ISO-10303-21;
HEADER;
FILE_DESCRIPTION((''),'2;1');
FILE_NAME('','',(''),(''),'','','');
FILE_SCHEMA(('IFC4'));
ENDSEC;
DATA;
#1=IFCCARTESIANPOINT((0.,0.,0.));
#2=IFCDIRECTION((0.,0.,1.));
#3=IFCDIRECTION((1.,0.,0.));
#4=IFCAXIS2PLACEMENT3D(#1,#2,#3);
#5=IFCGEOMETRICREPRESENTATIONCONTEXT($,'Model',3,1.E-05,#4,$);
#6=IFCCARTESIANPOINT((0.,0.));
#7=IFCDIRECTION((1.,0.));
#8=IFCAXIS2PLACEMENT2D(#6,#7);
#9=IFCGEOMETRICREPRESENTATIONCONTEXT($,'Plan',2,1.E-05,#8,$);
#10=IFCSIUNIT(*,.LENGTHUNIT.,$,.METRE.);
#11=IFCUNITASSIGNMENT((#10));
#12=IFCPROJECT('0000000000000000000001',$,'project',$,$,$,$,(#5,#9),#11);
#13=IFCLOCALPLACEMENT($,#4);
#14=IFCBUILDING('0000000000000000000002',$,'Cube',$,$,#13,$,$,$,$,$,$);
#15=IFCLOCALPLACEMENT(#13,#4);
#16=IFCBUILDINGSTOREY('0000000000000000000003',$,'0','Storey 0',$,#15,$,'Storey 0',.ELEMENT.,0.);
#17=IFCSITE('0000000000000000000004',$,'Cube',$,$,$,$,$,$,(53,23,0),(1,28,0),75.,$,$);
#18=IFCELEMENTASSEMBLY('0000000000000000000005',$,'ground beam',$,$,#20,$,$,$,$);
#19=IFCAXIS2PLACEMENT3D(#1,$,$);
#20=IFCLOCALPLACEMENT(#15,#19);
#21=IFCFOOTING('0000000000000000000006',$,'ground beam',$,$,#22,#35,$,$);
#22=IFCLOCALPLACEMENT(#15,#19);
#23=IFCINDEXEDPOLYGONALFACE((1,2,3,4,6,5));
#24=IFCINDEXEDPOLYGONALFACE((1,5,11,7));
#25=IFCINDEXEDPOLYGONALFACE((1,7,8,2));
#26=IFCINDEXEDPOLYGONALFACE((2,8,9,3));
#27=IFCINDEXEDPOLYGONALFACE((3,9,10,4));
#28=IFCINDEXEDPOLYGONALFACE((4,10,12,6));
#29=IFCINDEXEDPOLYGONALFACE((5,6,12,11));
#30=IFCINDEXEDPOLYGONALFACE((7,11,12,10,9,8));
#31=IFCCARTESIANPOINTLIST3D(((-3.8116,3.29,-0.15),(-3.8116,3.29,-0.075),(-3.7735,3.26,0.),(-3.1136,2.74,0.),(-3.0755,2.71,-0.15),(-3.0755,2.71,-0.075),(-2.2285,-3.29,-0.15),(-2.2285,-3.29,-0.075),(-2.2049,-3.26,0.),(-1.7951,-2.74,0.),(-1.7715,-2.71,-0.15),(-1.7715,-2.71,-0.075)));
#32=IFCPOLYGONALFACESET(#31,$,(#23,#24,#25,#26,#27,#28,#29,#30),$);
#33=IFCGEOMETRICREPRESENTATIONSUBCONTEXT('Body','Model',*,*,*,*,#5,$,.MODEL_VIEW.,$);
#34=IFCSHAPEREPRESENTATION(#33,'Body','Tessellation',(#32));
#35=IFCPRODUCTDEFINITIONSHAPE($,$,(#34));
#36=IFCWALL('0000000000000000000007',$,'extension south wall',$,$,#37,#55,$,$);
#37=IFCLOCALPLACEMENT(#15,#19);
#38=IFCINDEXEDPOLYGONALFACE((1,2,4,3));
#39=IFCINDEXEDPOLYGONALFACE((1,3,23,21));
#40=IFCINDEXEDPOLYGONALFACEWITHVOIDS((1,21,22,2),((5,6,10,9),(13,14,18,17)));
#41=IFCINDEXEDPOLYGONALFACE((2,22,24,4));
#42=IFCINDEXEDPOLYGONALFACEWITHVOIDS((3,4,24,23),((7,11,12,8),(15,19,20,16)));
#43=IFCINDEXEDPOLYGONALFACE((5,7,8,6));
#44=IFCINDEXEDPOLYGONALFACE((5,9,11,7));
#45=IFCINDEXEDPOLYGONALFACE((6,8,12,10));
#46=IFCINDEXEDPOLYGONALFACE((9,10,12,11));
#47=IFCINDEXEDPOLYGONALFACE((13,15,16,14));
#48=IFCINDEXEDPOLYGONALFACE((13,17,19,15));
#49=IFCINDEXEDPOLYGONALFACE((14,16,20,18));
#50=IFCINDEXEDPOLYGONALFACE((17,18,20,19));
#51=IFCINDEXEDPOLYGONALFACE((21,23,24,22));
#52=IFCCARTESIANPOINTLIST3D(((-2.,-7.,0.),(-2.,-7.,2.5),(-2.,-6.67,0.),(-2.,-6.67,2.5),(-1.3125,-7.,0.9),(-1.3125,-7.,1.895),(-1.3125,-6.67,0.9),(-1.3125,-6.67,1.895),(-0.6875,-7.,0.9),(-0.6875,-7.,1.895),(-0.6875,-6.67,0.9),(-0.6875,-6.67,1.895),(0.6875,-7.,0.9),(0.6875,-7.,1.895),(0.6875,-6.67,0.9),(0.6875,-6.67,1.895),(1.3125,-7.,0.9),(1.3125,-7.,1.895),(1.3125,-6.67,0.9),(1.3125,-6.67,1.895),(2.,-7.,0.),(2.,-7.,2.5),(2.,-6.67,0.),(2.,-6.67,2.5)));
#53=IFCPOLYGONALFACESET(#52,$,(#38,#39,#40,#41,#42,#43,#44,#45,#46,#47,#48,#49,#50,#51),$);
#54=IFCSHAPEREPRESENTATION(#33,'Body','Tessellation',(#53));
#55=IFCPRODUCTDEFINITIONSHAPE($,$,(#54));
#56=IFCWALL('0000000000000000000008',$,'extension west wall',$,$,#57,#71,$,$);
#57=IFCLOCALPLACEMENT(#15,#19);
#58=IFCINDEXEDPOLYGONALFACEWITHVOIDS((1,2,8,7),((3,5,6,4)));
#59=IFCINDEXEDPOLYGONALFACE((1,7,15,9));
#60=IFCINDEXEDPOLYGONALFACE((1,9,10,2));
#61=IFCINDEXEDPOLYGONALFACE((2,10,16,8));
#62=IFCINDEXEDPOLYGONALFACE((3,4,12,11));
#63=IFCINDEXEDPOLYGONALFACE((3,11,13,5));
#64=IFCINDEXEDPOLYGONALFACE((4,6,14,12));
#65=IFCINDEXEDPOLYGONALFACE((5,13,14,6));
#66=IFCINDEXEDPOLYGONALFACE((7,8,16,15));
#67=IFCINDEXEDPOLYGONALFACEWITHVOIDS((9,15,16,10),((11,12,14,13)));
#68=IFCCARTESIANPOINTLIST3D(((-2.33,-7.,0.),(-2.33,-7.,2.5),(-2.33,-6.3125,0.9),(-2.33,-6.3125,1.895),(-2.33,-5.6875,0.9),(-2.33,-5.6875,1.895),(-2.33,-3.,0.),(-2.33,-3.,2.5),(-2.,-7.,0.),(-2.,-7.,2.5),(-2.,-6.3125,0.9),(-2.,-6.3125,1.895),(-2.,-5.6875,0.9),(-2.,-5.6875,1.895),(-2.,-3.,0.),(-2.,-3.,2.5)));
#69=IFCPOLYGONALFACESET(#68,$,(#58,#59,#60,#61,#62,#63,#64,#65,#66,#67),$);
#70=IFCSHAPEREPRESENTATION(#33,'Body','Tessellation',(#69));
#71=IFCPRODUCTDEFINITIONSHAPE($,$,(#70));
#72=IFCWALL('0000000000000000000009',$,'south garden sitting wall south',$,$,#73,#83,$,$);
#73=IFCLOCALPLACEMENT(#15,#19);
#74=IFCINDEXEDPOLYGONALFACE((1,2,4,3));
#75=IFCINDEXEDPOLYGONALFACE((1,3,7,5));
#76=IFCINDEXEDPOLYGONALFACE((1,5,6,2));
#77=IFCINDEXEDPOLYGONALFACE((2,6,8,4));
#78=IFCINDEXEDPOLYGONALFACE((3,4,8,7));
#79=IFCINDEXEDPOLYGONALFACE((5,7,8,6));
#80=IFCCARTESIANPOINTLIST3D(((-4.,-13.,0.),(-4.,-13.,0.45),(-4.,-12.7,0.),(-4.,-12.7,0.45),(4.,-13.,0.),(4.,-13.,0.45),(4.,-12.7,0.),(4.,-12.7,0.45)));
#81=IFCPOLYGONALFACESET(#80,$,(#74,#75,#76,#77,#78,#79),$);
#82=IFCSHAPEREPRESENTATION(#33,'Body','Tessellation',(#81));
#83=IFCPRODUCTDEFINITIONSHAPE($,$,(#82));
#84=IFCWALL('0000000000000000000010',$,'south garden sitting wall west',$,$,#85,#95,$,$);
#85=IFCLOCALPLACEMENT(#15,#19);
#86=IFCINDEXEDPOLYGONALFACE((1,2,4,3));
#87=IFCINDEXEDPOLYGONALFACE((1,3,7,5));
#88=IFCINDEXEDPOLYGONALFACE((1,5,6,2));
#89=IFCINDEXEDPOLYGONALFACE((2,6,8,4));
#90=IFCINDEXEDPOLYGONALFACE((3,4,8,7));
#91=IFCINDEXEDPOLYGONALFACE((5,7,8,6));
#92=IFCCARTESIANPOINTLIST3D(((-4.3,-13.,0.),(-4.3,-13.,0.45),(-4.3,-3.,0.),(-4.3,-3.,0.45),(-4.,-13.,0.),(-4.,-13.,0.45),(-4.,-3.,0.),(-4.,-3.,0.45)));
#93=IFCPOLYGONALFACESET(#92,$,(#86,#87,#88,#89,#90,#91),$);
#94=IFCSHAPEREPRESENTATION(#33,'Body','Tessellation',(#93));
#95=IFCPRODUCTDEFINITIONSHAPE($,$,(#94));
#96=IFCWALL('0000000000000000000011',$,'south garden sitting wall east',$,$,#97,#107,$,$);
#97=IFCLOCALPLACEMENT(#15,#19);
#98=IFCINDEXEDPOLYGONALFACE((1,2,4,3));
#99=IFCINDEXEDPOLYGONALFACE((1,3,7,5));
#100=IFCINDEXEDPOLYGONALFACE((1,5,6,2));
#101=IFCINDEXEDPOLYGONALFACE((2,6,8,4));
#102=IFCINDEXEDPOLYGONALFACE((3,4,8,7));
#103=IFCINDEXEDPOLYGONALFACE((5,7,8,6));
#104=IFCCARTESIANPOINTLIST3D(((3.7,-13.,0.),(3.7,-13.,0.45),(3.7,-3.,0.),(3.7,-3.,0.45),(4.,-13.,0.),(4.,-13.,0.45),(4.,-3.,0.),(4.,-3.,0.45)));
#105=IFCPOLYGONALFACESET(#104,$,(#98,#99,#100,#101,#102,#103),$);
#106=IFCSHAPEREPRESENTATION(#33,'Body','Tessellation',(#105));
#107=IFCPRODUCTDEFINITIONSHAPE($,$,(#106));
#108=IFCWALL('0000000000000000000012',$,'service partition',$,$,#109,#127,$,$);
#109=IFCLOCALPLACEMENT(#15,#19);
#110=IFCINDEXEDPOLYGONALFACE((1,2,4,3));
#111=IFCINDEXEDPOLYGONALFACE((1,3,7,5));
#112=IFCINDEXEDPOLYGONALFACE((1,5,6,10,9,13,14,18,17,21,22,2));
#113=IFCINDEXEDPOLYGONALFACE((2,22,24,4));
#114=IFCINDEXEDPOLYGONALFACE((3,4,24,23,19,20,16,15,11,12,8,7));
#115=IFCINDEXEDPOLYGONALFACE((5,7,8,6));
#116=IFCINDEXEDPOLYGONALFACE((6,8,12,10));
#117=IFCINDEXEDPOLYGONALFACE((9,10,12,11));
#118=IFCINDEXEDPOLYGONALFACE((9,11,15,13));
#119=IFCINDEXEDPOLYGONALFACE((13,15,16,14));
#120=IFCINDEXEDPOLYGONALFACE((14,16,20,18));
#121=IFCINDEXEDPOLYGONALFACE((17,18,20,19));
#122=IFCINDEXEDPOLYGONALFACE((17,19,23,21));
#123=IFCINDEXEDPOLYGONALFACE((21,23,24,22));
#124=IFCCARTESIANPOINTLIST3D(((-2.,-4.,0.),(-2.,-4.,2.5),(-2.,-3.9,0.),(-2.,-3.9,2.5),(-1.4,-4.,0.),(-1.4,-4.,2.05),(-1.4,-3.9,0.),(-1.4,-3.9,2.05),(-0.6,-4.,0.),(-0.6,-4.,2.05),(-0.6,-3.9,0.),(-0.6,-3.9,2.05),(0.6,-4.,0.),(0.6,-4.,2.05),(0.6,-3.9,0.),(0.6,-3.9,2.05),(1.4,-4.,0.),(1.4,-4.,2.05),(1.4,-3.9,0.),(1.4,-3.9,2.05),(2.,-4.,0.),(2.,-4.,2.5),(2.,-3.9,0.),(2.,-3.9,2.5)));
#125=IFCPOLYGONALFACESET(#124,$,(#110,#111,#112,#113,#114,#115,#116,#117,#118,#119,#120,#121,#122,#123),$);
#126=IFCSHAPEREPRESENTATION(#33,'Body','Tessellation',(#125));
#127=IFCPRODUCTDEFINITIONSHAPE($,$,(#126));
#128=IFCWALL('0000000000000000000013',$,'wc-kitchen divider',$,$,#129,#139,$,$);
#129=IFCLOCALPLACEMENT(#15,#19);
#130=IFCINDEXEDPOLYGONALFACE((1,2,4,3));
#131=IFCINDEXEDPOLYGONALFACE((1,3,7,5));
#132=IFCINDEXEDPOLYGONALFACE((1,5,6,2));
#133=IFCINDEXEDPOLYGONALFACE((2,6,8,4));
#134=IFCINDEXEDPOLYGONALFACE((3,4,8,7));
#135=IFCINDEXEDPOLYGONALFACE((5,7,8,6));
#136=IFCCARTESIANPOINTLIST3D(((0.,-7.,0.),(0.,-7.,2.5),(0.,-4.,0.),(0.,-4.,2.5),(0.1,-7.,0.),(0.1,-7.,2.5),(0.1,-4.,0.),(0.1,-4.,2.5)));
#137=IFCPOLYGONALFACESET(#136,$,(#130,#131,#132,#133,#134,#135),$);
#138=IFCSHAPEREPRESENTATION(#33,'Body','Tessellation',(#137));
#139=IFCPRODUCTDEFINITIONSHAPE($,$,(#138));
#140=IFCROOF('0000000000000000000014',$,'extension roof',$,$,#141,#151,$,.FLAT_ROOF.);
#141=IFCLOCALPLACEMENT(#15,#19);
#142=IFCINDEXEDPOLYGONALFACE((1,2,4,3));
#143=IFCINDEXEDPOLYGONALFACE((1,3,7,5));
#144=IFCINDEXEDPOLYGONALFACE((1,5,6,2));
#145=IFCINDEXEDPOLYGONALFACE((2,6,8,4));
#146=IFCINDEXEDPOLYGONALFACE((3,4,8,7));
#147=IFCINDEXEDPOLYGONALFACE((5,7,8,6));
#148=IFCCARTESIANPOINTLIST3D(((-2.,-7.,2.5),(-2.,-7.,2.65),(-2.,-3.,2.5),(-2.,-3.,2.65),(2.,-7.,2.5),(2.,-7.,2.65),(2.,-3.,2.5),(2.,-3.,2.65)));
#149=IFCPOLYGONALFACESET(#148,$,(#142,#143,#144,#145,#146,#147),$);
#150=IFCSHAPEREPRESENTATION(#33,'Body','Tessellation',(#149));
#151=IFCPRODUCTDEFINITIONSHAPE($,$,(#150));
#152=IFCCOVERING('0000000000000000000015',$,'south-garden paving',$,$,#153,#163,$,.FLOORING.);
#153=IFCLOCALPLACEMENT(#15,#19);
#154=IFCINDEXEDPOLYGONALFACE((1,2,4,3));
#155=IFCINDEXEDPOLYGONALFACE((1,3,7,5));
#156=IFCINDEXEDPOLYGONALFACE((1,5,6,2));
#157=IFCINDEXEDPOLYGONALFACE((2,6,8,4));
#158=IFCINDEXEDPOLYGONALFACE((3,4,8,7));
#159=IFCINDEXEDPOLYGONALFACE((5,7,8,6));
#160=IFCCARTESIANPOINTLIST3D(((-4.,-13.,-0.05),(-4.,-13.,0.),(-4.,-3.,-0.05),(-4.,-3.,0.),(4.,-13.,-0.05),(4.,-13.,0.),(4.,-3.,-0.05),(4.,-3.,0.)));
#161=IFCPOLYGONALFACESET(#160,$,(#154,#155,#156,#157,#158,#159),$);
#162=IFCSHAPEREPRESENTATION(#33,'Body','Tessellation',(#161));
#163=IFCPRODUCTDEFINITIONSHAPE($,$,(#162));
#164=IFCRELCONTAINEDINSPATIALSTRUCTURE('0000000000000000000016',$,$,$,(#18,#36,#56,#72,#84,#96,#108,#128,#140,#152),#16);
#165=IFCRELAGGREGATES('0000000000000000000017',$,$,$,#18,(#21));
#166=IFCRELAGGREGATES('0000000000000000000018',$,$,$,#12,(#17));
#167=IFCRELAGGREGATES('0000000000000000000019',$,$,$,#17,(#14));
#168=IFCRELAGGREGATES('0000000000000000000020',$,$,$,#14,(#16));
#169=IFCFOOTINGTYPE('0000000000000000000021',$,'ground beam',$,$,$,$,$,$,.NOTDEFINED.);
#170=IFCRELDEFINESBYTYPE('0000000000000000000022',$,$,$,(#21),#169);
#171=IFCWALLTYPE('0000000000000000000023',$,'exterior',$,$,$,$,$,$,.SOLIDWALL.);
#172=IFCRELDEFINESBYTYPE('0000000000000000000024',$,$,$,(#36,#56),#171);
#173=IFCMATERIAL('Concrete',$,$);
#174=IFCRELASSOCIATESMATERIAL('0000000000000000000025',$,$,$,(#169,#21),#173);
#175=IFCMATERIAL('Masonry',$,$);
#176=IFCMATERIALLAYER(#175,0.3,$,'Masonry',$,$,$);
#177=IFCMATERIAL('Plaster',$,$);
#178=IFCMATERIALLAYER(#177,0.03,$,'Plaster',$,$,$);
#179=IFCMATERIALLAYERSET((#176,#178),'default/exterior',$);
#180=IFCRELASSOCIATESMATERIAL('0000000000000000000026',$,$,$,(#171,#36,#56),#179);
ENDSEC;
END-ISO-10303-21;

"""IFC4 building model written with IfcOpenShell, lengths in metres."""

from ifc_helpers import new_model, si_unit, frame, origin_with_axes, origin_2d_with_axis, place, context, subcontext, project, spatial, polyline, indexed_curve, outline, extrude, clip, halfspace, material, layer, layer_set, layer_usage, material_profile, profile_set, profile_usage, type_object, element, aggregate, save


model = new_model("IFC4")

# Units and contexts
model_context = context("Model", 3, precision=1e-05, world=origin_with_axes())
plan_context = context("Plan", 2, precision=1e-05, world=origin_2d_with_axis())
body_context_1 = subcontext(model_context, "Body", "Model", "MODEL_VIEW")
ifc_project = project(units=[si_unit("LENGTHUNIT", "METRE")], contexts=[model_context, plan_context])

# Site, building, storey
site = spatial("IfcSite", under=ifc_project, Name="Cube", RefLatitude=(53, 23, 0), RefLongitude=(1, 28, 0), RefElevation=75.0)
building_placement = place(None, origin_with_axes())
building = spatial("IfcBuilding", under=site, at=building_placement, Name="Cube")
storey_placement = place(building_placement, origin_with_axes())
storey = spatial("IfcBuildingStorey", under=building, at=storey_placement, Name="0", Description="Storey 0", LongName="Storey 0", CompositionType="ELEMENT", Elevation=0.0)

# Element assembly, footing
assembly_placement = place(storey_placement, origin_with_axes())
assembly = element("IfcElementAssembly", 1, at=assembly_placement, inside=storey, Name="ground beam")
ifc_material_1 = material(Name="Concrete")
ifc_material_profile = material_profile(ifc_material_1, outline(polyline([(-0.26, 0.0), (-0.29, -0.075), (-0.29, -0.15), (0.29, -0.15), (0.29, -0.075), (0.26, 0.0), (-0.26, 0.0)])))
ifc_profile_set = profile_set([ifc_material_profile])
ifc_profile_usage = profile_usage(ifc_profile_set)
footing_type = type_object("IfcFootingType", Name="ground beam", PredefinedType="NOTDEFINED", material=ifc_profile_set)
footing_placement = place(assembly_placement, frame((-1.7661, -3.9723, 0.0), z_axis=(-0.233915, 0.972257, 0.0), x_axis=(-0.972257, -0.233915, 0.0)))
footing = element("IfcFooting", 2, at=footing_placement, type_object=footing_type, material=ifc_profile_usage, Name="ground beam", context=body_context_1, shape_type="Clipping", body=[
    clip(clip(extrude(outline(polyline([(-0.26, 0.0), (-0.29, -0.075), (-0.29, -0.15), (0.29, -0.15), (0.29, -0.075), (0.26, 0.0), (-0.26, 0.0)])), origin_with_axes(), (0.0, 0.0, 1.0), 8.1712), halfspace(frame((0.0, 0.0, 1.0), z_axis=(-0.618904, 0.0, -0.785467), x_axis=(0.0, 1.0, 0.0)), False)), halfspace(frame((0.0, 0.0, 7.1712), z_axis=(-0.785467, 0.0, 0.618904), x_axis=(0.0, 1.0, 0.0)), False)),
])
aggregate(assembly, [footing])

# Wall, openings
ifc_material_2 = material(Name="Masonry")
ifc_layer_1 = layer(ifc_material_2, 0.3, Name="Masonry")
ifc_material_3 = material(Name="Plaster")
ifc_layer_2 = layer(ifc_material_3, 0.03, Name="Plaster")
ifc_layer_set = layer_set([ifc_layer_1, ifc_layer_2], Name="default/exterior")
ifc_layer_usage = layer_usage(ifc_layer_set, "AXIS2", "POSITIVE", 0.0)
wall_type = type_object("IfcWallType", Name="exterior", PredefinedType="SOLIDWALL", material=ifc_layer_set)
wall_1_placement = place(storey_placement, frame((-2.0, -7.0, 0.0), z_axis=(0.0, 0.0, 1.0), x_axis=(1.0, 0.0, 0.0)))
wall_1 = element("IfcWall", 3, at=wall_1_placement, inside=storey, type_object=wall_type, material=ifc_layer_usage, Name="extension south wall", context=body_context_1, shape_type="SweptSolid", body=[
    extrude(outline(indexed_curve([(0.0, 0.0), (0.0, 0.33), (4.0, 0.33), (4.0, 0.0), (0.0, 0.0)], self_intersect=False)), origin_with_axes(), (0.0, 0.0, 1.0), 2.5),
])
opening_1_placement = place(wall_1_placement, frame((0.6875, 0.0, 0.9), z_axis=(0.0, 0.0, 1.0), x_axis=(1.0, 0.0, 0.0)))
element("IfcOpeningElement", 4, at=opening_1_placement, cuts=wall_1, PredefinedType="OPENING", context=body_context_1, shape_type="SweptSolid", body=[
    extrude(outline(indexed_curve([(0.0, 0.0), (0.0, 0.5), (0.625, 0.5), (0.625, 0.0), (0.0, 0.0)], self_intersect=False)), origin_with_axes(), (0.0, 0.0, 1.0), 0.995),
])
opening_2_placement = place(wall_1_placement, frame((2.6875, 0.0, 0.9), z_axis=(0.0, 0.0, 1.0), x_axis=(1.0, 0.0, 0.0)))
element("IfcOpeningElement", 5, at=opening_2_placement, cuts=wall_1, PredefinedType="OPENING", context=body_context_1, shape_type="SweptSolid", body=[
    extrude(outline(indexed_curve([(0.0, 0.0), (0.0, 0.5), (0.625, 0.5), (0.625, 0.0), (0.0, 0.0)], self_intersect=False)), origin_with_axes(), (0.0, 0.0, 1.0), 0.995),
])

# Wall, opening
wall_2_placement = place(storey_placement, frame((-2.0, -7.0, 0.0), z_axis=(0.0, 0.0, 1.0), x_axis=(0.0, 1.0, 0.0)))
wall_2 = element("IfcWall", 6, at=wall_2_placement, inside=storey, type_object=wall_type, material=ifc_layer_usage, Name="extension west wall", context=body_context_1, shape_type="SweptSolid", body=[
    extrude(outline(indexed_curve([(0.0, 0.0), (0.0, 0.33), (4.0, 0.33), (4.0, 0.0), (0.0, 0.0)], self_intersect=False)), origin_with_axes(), (0.0, 0.0, 1.0), 2.5),
])
opening_3_placement = place(wall_2_placement, frame((0.6875, 0.0, 0.9), z_axis=(0.0, 0.0, 1.0), x_axis=(1.0, 0.0, 0.0)))
element("IfcOpeningElement", 7, at=opening_3_placement, cuts=wall_2, PredefinedType="OPENING", context=body_context_1, shape_type="SweptSolid", body=[
    extrude(outline(indexed_curve([(0.0, 0.0), (0.0, 0.5), (0.625, 0.5), (0.625, 0.0), (0.0, 0.0)], self_intersect=False)), origin_with_axes(), (0.0, 0.0, 1.0), 0.995),
])

# Walls
wall_3_placement = place(storey_placement, frame((-4.0, -13.0, 0.0), z_axis=(0.0, 0.0, 1.0), x_axis=(1.0, 0.0, 0.0)))
element("IfcWall", 8, at=wall_3_placement, inside=storey, Name="south garden sitting wall south", context=body_context_1, shape_type="SweptSolid", body=[
    extrude(outline(indexed_curve([(0.0, 0.0), (0.0, 0.3), (8.0, 0.3), (8.0, 0.0), (0.0, 0.0)], self_intersect=False)), origin_with_axes(), (0.0, 0.0, 1.0), 0.45),
])
for number, where, z_axis, x_axis, name in (
    (9, (-4.0, -13.0, 0.0), (0.0, 0.0, 1.0), (0.0, 1.0, 0.0), "south garden sitting wall west"),
    (10, (4.0, -13.0, 0.0), (0.0, 0.0, 1.0), (0.0, 1.0, 0.0), "south garden sitting wall east"),
):
    element("IfcWall", number, at=place(storey_placement, frame(where, z_axis=z_axis, x_axis=x_axis)), inside=storey, Name=name, context=body_context_1, shape_type="SweptSolid", body=[
        extrude(outline(indexed_curve([(0.0, 0.0), (0.0, 0.3), (10.0, 0.3), (10.0, 0.0), (0.0, 0.0)], self_intersect=False)), origin_with_axes(), (0.0, 0.0, 1.0), 0.45),
    ])

# Wall, openings
wall_4_placement = place(storey_placement, frame((-2.0, -4.0, 0.0), z_axis=(0.0, 0.0, 1.0), x_axis=(1.0, 0.0, 0.0)))
wall_4 = element("IfcWall", 11, at=wall_4_placement, inside=storey, Name="service partition", context=body_context_1, shape_type="SweptSolid", body=[
    extrude(outline(indexed_curve([(0.0, 0.0), (0.0, 0.1), (4.0, 0.1), (4.0, 0.0), (0.0, 0.0)], self_intersect=False)), origin_with_axes(), (0.0, 0.0, 1.0), 2.5),
])
opening_4_placement = place(wall_4_placement, frame((0.6, -0.05, 0.0), z_axis=(0.0, 0.0, 1.0), x_axis=(1.0, 0.0, 0.0)))
element("IfcOpeningElement", 12, at=opening_4_placement, cuts=wall_4, context=body_context_1, shape_type="SweptSolid", body=[
    extrude(outline(indexed_curve([(0.0, 0.0), (0.0, 0.3), (0.8, 0.3), (0.8, 0.0), (0.0, 0.0)], self_intersect=False)), origin_with_axes(), (0.0, 0.0, 1.0), 2.05),
])
opening_5_placement = place(wall_4_placement, frame((2.6, -0.05, 0.0), z_axis=(0.0, 0.0, 1.0), x_axis=(1.0, 0.0, 0.0)))
element("IfcOpeningElement", 13, at=opening_5_placement, cuts=wall_4, context=body_context_1, shape_type="SweptSolid", body=[
    extrude(outline(indexed_curve([(0.0, 0.0), (0.0, 0.3), (0.8, 0.3), (0.8, 0.0), (0.0, 0.0)], self_intersect=False)), origin_with_axes(), (0.0, 0.0, 1.0), 2.05),
])

# Wall
wall_5_placement = place(storey_placement, frame((0.0, -4.0, 0.0), z_axis=(0.0, 0.0, 1.0), x_axis=(0.0, -1.0, 0.0)))
element("IfcWall", 14, at=wall_5_placement, inside=storey, Name="wc-kitchen divider", context=body_context_1, shape_type="SweptSolid", body=[
    extrude(outline(indexed_curve([(0.0, 0.0), (0.0, 0.1), (3.0, 0.1), (3.0, 0.0), (0.0, 0.0)], self_intersect=False)), origin_with_axes(), (0.0, 0.0, 1.0), 2.5),
])

# Roof
roof_placement = place(storey_placement, frame((-2.0, -7.0, 2.5), z_axis=(0.0, 0.0, 1.0), x_axis=(1.0, 0.0, 0.0)))
element("IfcRoof", 15, at=roof_placement, inside=storey, Name="extension roof", PredefinedType="FLAT_ROOF", context=body_context_1, shape_type="SweptSolid", body=[
    extrude(outline(indexed_curve([(0.0, 0.0), (4.0, 0.0), (4.0, 4.0), (0.0, 4.0)])), None, (0.0, 0.0, 1.0), 0.15),
])

# Covering
covering_placement = place(storey_placement, frame((-4.0, -13.0, 0.0), z_axis=(0.0, 0.0, 1.0), x_axis=(1.0, 0.0, 0.0)))
element("IfcCovering", 16, at=covering_placement, inside=storey, Name="south-garden paving", PredefinedType="FLOORING", context=body_context_1, shape_type="SweptSolid", body=[
    extrude(outline(indexed_curve([(0.0, 0.0), (8.0, 0.0), (8.0, 10.0), (0.0, 10.0)])), None, (0.0, 0.0, -1.0), 0.05),
])

save(model, "model.ifc")
